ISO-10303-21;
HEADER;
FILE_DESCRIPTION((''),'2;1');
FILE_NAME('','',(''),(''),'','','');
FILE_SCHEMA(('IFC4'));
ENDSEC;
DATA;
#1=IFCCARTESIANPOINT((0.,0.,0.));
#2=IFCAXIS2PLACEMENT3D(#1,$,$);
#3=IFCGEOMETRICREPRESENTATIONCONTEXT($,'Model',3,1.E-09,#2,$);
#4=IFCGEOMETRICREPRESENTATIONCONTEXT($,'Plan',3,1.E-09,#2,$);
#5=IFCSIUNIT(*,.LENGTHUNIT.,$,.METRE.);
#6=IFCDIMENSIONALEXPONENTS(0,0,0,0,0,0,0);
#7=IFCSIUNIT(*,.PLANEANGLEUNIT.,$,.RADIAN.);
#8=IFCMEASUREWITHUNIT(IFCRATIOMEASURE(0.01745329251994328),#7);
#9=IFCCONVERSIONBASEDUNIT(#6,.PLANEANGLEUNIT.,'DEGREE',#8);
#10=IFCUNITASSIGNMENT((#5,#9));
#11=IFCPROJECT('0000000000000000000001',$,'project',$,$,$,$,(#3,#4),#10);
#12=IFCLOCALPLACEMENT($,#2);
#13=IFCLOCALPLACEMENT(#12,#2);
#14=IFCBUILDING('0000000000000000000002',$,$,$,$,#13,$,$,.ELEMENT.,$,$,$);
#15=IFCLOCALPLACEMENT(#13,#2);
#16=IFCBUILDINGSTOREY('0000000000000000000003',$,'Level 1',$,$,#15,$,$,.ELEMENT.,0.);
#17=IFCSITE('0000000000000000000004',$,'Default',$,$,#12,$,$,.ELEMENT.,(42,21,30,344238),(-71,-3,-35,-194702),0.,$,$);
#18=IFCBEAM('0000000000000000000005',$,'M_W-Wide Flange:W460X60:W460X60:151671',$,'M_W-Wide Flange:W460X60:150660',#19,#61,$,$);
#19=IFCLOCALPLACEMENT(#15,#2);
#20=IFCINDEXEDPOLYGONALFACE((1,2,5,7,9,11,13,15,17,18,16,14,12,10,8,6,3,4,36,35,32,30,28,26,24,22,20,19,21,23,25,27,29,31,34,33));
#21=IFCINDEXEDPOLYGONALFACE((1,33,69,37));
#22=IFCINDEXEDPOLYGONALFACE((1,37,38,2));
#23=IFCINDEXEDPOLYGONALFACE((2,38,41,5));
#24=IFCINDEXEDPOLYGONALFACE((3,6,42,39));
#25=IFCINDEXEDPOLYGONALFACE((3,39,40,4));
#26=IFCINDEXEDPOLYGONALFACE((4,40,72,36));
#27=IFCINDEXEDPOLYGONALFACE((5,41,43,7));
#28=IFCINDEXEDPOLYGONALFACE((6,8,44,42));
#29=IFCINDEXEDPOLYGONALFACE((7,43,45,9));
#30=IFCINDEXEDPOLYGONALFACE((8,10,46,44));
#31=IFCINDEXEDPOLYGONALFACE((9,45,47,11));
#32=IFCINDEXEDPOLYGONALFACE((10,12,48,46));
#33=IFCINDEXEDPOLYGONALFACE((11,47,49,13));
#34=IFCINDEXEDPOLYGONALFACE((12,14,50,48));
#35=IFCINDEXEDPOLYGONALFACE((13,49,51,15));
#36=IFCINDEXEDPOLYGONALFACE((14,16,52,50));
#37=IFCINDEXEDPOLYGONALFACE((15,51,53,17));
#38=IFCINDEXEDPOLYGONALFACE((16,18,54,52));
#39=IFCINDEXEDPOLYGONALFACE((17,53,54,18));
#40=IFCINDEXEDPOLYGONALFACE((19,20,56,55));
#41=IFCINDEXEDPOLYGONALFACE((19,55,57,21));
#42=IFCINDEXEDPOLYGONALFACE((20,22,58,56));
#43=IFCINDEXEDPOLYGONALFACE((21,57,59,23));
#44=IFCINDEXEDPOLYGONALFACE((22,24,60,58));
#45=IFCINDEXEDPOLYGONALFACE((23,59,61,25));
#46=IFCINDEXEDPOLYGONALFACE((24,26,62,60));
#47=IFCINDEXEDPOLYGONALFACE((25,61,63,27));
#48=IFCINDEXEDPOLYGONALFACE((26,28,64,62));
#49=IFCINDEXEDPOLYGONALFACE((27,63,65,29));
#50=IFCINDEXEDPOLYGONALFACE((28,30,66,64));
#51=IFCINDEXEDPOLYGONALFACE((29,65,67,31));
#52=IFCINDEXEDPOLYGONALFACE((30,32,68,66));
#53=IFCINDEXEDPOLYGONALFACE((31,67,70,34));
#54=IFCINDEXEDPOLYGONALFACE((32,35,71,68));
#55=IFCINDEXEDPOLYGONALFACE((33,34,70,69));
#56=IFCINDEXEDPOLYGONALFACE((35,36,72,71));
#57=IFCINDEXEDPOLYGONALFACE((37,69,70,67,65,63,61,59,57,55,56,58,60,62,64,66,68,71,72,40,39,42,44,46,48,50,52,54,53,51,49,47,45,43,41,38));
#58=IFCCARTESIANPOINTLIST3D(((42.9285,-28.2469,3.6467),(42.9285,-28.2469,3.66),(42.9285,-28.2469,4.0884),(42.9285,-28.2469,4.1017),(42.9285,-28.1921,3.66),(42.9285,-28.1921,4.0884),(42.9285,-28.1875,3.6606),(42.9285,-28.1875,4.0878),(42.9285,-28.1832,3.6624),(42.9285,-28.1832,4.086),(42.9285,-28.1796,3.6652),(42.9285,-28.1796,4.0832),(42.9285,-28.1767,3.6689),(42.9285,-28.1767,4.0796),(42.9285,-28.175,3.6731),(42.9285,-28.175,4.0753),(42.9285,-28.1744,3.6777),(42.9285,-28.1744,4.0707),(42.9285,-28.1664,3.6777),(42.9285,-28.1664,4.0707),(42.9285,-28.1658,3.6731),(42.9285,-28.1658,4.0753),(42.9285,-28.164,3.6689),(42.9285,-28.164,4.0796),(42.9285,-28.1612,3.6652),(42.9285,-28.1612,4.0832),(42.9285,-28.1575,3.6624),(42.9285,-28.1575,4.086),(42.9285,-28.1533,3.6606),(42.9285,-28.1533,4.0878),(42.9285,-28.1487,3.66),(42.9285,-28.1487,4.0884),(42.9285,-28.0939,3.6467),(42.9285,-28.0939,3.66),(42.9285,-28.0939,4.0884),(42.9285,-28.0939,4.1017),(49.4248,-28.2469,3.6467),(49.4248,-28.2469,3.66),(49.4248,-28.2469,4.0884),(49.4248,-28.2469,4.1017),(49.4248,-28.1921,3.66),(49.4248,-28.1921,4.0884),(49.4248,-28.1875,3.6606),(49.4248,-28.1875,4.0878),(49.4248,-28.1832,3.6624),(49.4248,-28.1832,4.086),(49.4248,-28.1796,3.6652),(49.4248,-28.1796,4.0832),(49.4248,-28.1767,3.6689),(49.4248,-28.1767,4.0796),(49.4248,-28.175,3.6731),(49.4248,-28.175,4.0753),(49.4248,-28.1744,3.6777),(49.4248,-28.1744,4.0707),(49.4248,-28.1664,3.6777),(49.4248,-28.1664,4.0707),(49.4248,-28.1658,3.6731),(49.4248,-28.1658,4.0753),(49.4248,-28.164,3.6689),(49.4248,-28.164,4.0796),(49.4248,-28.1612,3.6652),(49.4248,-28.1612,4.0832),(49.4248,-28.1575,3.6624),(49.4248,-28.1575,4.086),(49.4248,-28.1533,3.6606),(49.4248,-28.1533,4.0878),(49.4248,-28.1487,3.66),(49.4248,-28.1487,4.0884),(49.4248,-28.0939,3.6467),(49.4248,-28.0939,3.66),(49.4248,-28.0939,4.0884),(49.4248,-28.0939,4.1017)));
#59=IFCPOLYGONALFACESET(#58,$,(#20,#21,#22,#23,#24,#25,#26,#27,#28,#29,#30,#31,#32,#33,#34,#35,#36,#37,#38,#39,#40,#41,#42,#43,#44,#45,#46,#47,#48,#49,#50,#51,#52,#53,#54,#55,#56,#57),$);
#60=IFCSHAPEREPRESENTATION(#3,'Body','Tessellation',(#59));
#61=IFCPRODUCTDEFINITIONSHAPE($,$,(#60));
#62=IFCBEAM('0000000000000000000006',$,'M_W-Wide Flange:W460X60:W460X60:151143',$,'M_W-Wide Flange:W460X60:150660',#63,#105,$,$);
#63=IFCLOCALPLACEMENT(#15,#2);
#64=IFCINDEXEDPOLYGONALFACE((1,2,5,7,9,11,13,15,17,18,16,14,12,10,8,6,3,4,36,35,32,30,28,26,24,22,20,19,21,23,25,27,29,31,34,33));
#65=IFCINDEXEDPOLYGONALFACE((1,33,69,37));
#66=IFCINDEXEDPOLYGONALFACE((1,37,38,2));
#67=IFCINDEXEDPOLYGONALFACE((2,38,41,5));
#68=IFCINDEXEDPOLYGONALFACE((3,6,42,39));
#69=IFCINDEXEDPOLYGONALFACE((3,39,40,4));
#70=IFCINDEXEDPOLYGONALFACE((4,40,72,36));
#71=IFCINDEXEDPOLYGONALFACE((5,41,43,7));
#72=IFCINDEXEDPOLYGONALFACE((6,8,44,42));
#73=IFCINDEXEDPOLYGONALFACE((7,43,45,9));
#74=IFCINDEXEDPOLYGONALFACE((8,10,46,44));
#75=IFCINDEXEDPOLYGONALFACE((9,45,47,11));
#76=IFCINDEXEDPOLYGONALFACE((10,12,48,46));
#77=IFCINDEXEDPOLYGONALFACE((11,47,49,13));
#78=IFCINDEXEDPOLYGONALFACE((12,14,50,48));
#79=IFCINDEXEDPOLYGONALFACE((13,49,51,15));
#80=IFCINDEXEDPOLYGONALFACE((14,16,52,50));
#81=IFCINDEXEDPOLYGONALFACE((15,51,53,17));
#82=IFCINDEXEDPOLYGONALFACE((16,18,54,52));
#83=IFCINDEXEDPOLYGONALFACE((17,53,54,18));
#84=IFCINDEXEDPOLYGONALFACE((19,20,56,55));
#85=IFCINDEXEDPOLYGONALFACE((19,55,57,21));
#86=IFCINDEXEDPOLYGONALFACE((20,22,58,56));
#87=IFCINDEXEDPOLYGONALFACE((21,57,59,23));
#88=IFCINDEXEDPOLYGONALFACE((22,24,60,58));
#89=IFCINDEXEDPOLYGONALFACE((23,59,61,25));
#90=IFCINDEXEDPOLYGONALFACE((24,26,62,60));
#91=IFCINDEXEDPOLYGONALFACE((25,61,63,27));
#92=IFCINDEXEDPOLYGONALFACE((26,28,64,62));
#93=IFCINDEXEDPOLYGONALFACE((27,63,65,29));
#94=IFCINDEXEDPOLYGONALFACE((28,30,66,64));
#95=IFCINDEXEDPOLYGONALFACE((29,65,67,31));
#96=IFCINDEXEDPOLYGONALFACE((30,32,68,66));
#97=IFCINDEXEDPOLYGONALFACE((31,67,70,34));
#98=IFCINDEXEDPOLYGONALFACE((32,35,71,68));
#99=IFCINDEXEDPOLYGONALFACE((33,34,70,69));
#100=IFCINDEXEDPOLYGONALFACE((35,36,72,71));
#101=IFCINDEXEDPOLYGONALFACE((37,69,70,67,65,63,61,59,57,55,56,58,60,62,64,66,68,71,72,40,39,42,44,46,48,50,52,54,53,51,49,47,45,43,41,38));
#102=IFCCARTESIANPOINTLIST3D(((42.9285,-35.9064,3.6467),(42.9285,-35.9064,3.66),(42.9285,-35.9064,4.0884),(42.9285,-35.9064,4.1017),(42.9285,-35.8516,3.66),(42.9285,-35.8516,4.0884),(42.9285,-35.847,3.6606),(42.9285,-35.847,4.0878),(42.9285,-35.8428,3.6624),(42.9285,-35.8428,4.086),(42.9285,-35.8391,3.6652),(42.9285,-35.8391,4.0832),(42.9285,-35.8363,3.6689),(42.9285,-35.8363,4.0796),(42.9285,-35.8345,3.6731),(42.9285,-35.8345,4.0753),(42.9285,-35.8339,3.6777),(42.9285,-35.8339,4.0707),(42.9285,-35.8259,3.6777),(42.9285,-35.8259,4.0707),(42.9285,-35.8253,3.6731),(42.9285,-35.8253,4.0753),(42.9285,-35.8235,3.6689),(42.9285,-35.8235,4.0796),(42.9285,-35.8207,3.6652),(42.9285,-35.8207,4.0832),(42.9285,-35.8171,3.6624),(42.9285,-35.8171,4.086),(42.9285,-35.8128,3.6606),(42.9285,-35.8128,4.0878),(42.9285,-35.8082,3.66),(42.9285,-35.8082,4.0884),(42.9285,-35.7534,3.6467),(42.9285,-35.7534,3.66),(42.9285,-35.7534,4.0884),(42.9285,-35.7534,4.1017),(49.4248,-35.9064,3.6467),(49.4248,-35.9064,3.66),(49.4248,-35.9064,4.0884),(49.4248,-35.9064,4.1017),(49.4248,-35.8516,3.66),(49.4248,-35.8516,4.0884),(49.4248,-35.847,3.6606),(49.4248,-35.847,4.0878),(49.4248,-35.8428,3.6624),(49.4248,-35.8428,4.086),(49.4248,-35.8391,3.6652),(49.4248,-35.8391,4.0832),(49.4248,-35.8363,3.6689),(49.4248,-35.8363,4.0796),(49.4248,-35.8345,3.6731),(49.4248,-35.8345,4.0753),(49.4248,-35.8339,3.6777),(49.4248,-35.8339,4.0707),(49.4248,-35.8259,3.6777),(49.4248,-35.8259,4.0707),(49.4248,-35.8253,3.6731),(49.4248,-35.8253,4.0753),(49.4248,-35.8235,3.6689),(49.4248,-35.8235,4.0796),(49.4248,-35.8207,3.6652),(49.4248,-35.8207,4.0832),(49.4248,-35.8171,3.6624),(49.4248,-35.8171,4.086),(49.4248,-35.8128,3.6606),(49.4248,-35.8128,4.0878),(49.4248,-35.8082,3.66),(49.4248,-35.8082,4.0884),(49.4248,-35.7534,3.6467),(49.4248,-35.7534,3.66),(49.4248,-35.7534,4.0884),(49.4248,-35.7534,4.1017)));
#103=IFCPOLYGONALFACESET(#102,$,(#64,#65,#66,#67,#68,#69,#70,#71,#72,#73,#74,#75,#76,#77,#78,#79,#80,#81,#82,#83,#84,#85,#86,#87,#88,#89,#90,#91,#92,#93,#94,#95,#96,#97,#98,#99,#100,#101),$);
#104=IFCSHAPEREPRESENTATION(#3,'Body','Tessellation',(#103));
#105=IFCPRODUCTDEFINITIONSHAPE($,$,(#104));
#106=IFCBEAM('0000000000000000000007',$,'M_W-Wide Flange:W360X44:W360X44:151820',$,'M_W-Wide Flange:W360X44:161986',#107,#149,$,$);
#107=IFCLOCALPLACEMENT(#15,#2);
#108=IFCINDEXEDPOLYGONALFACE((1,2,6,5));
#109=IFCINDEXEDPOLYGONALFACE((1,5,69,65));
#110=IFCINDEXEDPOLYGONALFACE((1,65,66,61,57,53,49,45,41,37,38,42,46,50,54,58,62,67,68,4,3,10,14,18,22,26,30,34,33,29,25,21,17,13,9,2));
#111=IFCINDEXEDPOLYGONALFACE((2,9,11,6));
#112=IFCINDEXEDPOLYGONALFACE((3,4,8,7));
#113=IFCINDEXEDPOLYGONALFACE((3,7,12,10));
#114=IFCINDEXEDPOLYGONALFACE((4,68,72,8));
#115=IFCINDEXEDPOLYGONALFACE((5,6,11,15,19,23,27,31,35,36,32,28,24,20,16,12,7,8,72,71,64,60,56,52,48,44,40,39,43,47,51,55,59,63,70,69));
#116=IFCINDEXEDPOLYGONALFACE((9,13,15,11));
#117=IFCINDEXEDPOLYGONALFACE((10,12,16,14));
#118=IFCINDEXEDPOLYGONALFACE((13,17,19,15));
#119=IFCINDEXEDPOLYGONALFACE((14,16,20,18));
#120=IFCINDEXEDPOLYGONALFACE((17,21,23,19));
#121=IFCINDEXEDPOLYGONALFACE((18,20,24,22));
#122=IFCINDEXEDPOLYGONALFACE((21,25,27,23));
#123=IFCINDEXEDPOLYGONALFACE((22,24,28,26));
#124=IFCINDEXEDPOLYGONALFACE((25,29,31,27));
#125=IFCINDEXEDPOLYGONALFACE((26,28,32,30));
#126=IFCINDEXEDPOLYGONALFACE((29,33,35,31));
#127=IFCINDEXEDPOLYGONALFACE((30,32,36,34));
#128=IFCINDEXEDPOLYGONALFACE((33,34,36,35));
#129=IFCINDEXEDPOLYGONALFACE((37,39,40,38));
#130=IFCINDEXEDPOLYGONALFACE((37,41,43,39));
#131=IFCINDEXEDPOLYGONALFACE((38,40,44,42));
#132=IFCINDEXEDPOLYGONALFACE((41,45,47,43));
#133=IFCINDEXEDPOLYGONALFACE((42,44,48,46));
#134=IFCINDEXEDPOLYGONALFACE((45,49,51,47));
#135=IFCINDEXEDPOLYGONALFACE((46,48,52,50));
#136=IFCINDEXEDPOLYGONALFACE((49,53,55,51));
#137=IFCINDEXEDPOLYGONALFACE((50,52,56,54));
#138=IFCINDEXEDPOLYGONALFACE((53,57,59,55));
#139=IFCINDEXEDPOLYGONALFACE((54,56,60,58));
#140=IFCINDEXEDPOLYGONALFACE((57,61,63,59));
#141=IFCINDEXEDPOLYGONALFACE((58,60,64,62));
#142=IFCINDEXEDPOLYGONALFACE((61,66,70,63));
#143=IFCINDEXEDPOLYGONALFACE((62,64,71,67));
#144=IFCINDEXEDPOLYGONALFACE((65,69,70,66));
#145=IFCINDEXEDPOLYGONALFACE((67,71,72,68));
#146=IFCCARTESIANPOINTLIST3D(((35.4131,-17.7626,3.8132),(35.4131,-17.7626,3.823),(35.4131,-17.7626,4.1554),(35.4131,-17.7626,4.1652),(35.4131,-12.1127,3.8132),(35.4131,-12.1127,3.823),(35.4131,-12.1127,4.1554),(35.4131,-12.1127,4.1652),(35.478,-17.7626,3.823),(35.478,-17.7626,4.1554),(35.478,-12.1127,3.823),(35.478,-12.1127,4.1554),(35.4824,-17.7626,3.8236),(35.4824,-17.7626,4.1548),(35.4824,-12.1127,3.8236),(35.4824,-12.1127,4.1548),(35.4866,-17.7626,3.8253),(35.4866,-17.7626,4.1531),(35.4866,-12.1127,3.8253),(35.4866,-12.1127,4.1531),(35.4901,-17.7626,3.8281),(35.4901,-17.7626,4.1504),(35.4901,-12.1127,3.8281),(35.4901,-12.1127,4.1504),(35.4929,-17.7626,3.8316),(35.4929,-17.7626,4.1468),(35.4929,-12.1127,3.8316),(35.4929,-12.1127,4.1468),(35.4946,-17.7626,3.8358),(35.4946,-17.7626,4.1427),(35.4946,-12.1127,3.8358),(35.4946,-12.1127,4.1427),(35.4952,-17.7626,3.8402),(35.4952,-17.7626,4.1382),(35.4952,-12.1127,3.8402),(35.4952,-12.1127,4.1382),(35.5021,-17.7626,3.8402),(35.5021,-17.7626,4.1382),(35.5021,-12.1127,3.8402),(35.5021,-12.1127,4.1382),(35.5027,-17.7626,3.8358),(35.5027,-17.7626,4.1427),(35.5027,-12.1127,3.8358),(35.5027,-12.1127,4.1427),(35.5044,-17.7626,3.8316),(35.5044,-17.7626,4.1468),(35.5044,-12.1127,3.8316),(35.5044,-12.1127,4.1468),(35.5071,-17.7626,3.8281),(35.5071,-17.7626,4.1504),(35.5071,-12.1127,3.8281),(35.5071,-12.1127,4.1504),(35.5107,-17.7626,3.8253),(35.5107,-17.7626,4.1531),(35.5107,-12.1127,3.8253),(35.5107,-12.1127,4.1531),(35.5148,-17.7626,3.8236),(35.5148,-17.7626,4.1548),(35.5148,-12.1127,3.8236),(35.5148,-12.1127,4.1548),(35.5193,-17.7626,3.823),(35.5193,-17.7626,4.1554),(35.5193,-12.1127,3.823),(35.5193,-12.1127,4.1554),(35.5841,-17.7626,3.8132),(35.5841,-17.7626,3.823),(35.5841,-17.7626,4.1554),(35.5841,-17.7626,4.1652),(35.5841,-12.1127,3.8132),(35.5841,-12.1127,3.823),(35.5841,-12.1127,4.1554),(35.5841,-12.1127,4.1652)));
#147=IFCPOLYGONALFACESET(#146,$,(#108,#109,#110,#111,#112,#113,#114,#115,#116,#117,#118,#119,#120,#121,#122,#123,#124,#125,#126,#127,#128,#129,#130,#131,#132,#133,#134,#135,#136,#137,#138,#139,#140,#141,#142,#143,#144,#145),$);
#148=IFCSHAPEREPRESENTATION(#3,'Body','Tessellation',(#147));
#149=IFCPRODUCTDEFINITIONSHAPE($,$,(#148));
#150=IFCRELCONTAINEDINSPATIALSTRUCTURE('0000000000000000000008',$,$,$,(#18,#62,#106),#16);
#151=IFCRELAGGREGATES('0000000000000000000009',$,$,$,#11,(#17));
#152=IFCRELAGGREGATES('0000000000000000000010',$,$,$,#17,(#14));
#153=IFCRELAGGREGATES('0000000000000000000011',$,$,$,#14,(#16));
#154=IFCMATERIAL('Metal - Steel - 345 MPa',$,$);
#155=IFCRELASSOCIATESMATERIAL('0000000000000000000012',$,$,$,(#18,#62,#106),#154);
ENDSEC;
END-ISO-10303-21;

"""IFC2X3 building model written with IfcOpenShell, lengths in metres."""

from ifc_helpers import new_model, entity, si_unit, converted_unit, frame, frame_2d, origin, place, context, project, spatial, polyline, circle_curve, parameter, trimmed, segment, composite_curve, outline, extrude, material, element, save


model = new_model("IFC2X3")

# Units and contexts
model_context = context("Model", 3, precision=1e-09, world=origin())
plan_context = context("Plan", 3, precision=1e-09, world=origin())
ifc_project = project(units=[si_unit("LENGTHUNIT", "METRE"), converted_unit("PLANEANGLEUNIT", "DEGREE", entity("IfcRatioMeasure", 0.01745329251994328), si_unit("PLANEANGLEUNIT", "RADIAN"), dimensions=[0, 0, 0, 0, 0, 0, 0])], contexts=[model_context, plan_context])

# Site, building, storey
site_placement = place(None, origin())
site = spatial("IfcSite", under=ifc_project, at=site_placement, Name="Default", CompositionType="ELEMENT", RefLatitude=(42, 21, 30, 344238), RefLongitude=(-71, -3, -35, -194702), RefElevation=0.0)
building_placement = place(site_placement, origin())
building = spatial("IfcBuilding", under=site, at=building_placement, CompositionType="ELEMENT")
storey_placement = place(building_placement, origin())
storey = spatial("IfcBuildingStorey", under=building, at=storey_placement, Name="Level 1", CompositionType="ELEMENT", Elevation=0.0)

# Beams
ifc_material = material(Name="Metal - Steel - 345 MPa")
beam_1_placement = place(storey_placement, frame((42.8138, -28.1704, 4.2672), z_axis=(0.0, 0.0, 1.0), x_axis=(0.0, -1.0, 0.0)))
element("IfcBeam", 1, at=beam_1_placement, inside=storey, material=ifc_material, Name="M_W-Wide Flange:W460X60:W460X60:151671", ObjectType="M_W-Wide Flange:W460X60:150660", context=model_context, shape_type="SweptSolid", body=[
    extrude(outline(composite_curve([segment(polyline([(-0.0765, -0.2142), (-0.0765, -0.2275)]), True, "CONTINUOUS"), segment(polyline([(-0.0765, -0.2275), (0.0765, -0.2275)]), True, "CONTINUOUS"), segment(polyline([(0.0765, -0.2275), (0.0765, -0.2142)]), True, "CONTINUOUS"), segment(polyline([(0.0765, -0.2142), (0.0217, -0.2142)]), True, "CONTINUOUS"), segment(trimmed(circle_curve(frame_2d((0.0217, -0.1965), x_axis=(1.0, 0.0)), 0.0177), [parameter(180.0)], [parameter(270.0)], True, "PARAMETER"), False, "CONTINUOUS"), segment(polyline([(0.004, -0.1965), (0.004, 0.1965)]), True, "CONTINUOUS"), segment(trimmed(circle_curve(frame_2d((0.0217, 0.1965), x_axis=(1.0, 0.0)), 0.0177), [parameter(90.0)], [parameter(180.0)], True, "PARAMETER"), False, "CONTINUOUS"), segment(polyline([(0.0217, 0.2142), (0.0765, 0.2142)]), True, "CONTINUOUS"), segment(polyline([(0.0765, 0.2142), (0.0765, 0.2275)]), True, "CONTINUOUS"), segment(polyline([(0.0765, 0.2275), (-0.0765, 0.2275)]), True, "CONTINUOUS"), segment(polyline([(-0.0765, 0.2275), (-0.0765, 0.2142)]), True, "CONTINUOUS"), segment(polyline([(-0.0765, 0.2142), (-0.0217, 0.2142)]), True, "CONTINUOUS"), segment(trimmed(circle_curve(frame_2d((-0.0217, 0.1965), x_axis=(1.0, 0.0)), 0.0177), [parameter(360.0)], [parameter(90.0)], True, "PARAMETER"), False, "CONTINUOUS"), segment(polyline([(-0.004, 0.1965), (-0.004, -0.1965)]), True, "CONTINUOUS"), segment(trimmed(circle_curve(frame_2d((-0.0217, -0.1965), x_axis=(1.0, 0.0)), 0.0177), [parameter(270.0)], [parameter(0.0)], True, "PARAMETER"), False, "CONTINUOUS"), segment(polyline([(-0.0217, -0.2142), (-0.0765, -0.2142)]), True, "CONTINUOUS")], self_intersect=False)), frame((0.0, 0.1147, -0.393), z_axis=(0.0, -1.0, 0.0), x_axis=(1.0, 0.0, 0.0)), (0.0, 0.0, -1.0), 6.4963),
])
beam_2_placement = place(storey_placement, frame((49.5395, -35.8299, 4.2672), z_axis=(0.0, 0.0, 1.0), x_axis=(0.0, 1.0, 0.0)))
element("IfcBeam", 2, at=beam_2_placement, inside=storey, material=ifc_material, Name="M_W-Wide Flange:W460X60:W460X60:151143", ObjectType="M_W-Wide Flange:W460X60:150660", context=model_context, shape_type="SweptSolid", body=[
    extrude(outline(composite_curve([segment(polyline([(0.2142, -0.0765), (0.2275, -0.0765)]), True, "CONTINUOUS"), segment(polyline([(0.2275, -0.0765), (0.2275, 0.0765)]), True, "CONTINUOUS"), segment(polyline([(0.2275, 0.0765), (0.2142, 0.0765)]), True, "CONTINUOUS"), segment(polyline([(0.2142, 0.0765), (0.2142, 0.0217)]), True, "CONTINUOUS"), segment(trimmed(circle_curve(frame_2d((0.1965, 0.0217), x_axis=(0.0, 1.0)), 0.0177), [parameter(180.0)], [parameter(270.0)], True, "PARAMETER"), False, "CONTINUOUS"), segment(polyline([(0.1965, 0.004), (-0.1965, 0.004)]), True, "CONTINUOUS"), segment(trimmed(circle_curve(frame_2d((-0.1965, 0.0217), x_axis=(0.0, 1.0)), 0.0177), [parameter(90.0)], [parameter(180.0)], True, "PARAMETER"), False, "CONTINUOUS"), segment(polyline([(-0.2142, 0.0217), (-0.2142, 0.0765)]), True, "CONTINUOUS"), segment(polyline([(-0.2142, 0.0765), (-0.2275, 0.0765)]), True, "CONTINUOUS"), segment(polyline([(-0.2275, 0.0765), (-0.2275, -0.0765)]), True, "CONTINUOUS"), segment(polyline([(-0.2275, -0.0765), (-0.2142, -0.0765)]), True, "CONTINUOUS"), segment(polyline([(-0.2142, -0.0765), (-0.2142, -0.0217)]), True, "CONTINUOUS"), segment(trimmed(circle_curve(frame_2d((-0.1965, -0.0217), x_axis=(0.0, 1.0)), 0.0177), [parameter(360.0)], [parameter(90.0)], True, "PARAMETER"), False, "CONTINUOUS"), segment(polyline([(-0.1965, -0.004), (0.1965, -0.004)]), True, "CONTINUOUS"), segment(trimmed(circle_curve(frame_2d((0.1965, -0.0217), x_axis=(0.0, 1.0)), 0.0177), [parameter(270.0)], [parameter(0.0)], True, "PARAMETER"), False, "CONTINUOUS"), segment(polyline([(0.2142, -0.0217), (0.2142, -0.0765)]), True, "CONTINUOUS")], self_intersect=False)), frame((0.0, 6.611, -0.393), z_axis=(0.0, -1.0, 0.0), x_axis=(0.0, 0.0, -1.0)), (0.0, 0.0, 1.0), 6.4963),
])
beam_3_placement = place(storey_placement, frame((35.4986, -17.9038, 4.2672)))
element("IfcBeam", 3, at=beam_3_placement, inside=storey, material=ifc_material, Name="M_W-Wide Flange:W360X44:W360X44:151820", ObjectType="M_W-Wide Flange:W360X44:161986", context=model_context, shape_type="SweptSolid", body=[
    extrude(outline(composite_curve([segment(polyline([(-0.0855, -0.1662), (-0.0855, -0.176)]), True, "CONTINUOUS"), segment(polyline([(-0.0855, -0.176), (0.0855, -0.176)]), True, "CONTINUOUS"), segment(polyline([(0.0855, -0.176), (0.0855, -0.1662)]), True, "CONTINUOUS"), segment(polyline([(0.0855, -0.1662), (0.0207, -0.1662)]), True, "CONTINUOUS"), segment(trimmed(circle_curve(frame_2d((0.0207, -0.149), x_axis=(1.0, 0.0)), 0.0172), [parameter(180.0)], [parameter(270.0)], True, "PARAMETER"), False, "CONTINUOUS"), segment(polyline([(0.0035, -0.149), (0.0035, 0.149)]), True, "CONTINUOUS"), segment(trimmed(circle_curve(frame_2d((0.0207, 0.149), x_axis=(1.0, 0.0)), 0.0172), [parameter(90.0)], [parameter(180.0)], True, "PARAMETER"), False, "CONTINUOUS"), segment(polyline([(0.0207, 0.1662), (0.0855, 0.1662)]), True, "CONTINUOUS"), segment(polyline([(0.0855, 0.1662), (0.0855, 0.176)]), True, "CONTINUOUS"), segment(polyline([(0.0855, 0.176), (-0.0855, 0.176)]), True, "CONTINUOUS"), segment(polyline([(-0.0855, 0.176), (-0.0855, 0.1662)]), True, "CONTINUOUS"), segment(polyline([(-0.0855, 0.1662), (-0.0206, 0.1662)]), True, "CONTINUOUS"), segment(trimmed(circle_curve(frame_2d((-0.0206, 0.149), x_axis=(1.0, 0.0)), 0.0172), [parameter(360.0)], [parameter(90.0)], True, "PARAMETER"), False, "CONTINUOUS"), segment(polyline([(-0.0034, 0.149), (-0.0034, -0.149)]), True, "CONTINUOUS"), segment(trimmed(circle_curve(frame_2d((-0.0206, -0.149), x_axis=(1.0, 0.0)), 0.0172), [parameter(270.0)], [parameter(0.0)], True, "PARAMETER"), False, "CONTINUOUS"), segment(polyline([(-0.0206, -0.1662), (-0.0855, -0.1662)]), True, "CONTINUOUS")], self_intersect=False)), frame((0.0, 0.1412, -0.278), z_axis=(0.0, -1.0, 0.0), x_axis=(1.0, 0.0, 0.0)), (0.0, 0.0, -1.0), 5.65),
])

save(model, "model.ifc")
